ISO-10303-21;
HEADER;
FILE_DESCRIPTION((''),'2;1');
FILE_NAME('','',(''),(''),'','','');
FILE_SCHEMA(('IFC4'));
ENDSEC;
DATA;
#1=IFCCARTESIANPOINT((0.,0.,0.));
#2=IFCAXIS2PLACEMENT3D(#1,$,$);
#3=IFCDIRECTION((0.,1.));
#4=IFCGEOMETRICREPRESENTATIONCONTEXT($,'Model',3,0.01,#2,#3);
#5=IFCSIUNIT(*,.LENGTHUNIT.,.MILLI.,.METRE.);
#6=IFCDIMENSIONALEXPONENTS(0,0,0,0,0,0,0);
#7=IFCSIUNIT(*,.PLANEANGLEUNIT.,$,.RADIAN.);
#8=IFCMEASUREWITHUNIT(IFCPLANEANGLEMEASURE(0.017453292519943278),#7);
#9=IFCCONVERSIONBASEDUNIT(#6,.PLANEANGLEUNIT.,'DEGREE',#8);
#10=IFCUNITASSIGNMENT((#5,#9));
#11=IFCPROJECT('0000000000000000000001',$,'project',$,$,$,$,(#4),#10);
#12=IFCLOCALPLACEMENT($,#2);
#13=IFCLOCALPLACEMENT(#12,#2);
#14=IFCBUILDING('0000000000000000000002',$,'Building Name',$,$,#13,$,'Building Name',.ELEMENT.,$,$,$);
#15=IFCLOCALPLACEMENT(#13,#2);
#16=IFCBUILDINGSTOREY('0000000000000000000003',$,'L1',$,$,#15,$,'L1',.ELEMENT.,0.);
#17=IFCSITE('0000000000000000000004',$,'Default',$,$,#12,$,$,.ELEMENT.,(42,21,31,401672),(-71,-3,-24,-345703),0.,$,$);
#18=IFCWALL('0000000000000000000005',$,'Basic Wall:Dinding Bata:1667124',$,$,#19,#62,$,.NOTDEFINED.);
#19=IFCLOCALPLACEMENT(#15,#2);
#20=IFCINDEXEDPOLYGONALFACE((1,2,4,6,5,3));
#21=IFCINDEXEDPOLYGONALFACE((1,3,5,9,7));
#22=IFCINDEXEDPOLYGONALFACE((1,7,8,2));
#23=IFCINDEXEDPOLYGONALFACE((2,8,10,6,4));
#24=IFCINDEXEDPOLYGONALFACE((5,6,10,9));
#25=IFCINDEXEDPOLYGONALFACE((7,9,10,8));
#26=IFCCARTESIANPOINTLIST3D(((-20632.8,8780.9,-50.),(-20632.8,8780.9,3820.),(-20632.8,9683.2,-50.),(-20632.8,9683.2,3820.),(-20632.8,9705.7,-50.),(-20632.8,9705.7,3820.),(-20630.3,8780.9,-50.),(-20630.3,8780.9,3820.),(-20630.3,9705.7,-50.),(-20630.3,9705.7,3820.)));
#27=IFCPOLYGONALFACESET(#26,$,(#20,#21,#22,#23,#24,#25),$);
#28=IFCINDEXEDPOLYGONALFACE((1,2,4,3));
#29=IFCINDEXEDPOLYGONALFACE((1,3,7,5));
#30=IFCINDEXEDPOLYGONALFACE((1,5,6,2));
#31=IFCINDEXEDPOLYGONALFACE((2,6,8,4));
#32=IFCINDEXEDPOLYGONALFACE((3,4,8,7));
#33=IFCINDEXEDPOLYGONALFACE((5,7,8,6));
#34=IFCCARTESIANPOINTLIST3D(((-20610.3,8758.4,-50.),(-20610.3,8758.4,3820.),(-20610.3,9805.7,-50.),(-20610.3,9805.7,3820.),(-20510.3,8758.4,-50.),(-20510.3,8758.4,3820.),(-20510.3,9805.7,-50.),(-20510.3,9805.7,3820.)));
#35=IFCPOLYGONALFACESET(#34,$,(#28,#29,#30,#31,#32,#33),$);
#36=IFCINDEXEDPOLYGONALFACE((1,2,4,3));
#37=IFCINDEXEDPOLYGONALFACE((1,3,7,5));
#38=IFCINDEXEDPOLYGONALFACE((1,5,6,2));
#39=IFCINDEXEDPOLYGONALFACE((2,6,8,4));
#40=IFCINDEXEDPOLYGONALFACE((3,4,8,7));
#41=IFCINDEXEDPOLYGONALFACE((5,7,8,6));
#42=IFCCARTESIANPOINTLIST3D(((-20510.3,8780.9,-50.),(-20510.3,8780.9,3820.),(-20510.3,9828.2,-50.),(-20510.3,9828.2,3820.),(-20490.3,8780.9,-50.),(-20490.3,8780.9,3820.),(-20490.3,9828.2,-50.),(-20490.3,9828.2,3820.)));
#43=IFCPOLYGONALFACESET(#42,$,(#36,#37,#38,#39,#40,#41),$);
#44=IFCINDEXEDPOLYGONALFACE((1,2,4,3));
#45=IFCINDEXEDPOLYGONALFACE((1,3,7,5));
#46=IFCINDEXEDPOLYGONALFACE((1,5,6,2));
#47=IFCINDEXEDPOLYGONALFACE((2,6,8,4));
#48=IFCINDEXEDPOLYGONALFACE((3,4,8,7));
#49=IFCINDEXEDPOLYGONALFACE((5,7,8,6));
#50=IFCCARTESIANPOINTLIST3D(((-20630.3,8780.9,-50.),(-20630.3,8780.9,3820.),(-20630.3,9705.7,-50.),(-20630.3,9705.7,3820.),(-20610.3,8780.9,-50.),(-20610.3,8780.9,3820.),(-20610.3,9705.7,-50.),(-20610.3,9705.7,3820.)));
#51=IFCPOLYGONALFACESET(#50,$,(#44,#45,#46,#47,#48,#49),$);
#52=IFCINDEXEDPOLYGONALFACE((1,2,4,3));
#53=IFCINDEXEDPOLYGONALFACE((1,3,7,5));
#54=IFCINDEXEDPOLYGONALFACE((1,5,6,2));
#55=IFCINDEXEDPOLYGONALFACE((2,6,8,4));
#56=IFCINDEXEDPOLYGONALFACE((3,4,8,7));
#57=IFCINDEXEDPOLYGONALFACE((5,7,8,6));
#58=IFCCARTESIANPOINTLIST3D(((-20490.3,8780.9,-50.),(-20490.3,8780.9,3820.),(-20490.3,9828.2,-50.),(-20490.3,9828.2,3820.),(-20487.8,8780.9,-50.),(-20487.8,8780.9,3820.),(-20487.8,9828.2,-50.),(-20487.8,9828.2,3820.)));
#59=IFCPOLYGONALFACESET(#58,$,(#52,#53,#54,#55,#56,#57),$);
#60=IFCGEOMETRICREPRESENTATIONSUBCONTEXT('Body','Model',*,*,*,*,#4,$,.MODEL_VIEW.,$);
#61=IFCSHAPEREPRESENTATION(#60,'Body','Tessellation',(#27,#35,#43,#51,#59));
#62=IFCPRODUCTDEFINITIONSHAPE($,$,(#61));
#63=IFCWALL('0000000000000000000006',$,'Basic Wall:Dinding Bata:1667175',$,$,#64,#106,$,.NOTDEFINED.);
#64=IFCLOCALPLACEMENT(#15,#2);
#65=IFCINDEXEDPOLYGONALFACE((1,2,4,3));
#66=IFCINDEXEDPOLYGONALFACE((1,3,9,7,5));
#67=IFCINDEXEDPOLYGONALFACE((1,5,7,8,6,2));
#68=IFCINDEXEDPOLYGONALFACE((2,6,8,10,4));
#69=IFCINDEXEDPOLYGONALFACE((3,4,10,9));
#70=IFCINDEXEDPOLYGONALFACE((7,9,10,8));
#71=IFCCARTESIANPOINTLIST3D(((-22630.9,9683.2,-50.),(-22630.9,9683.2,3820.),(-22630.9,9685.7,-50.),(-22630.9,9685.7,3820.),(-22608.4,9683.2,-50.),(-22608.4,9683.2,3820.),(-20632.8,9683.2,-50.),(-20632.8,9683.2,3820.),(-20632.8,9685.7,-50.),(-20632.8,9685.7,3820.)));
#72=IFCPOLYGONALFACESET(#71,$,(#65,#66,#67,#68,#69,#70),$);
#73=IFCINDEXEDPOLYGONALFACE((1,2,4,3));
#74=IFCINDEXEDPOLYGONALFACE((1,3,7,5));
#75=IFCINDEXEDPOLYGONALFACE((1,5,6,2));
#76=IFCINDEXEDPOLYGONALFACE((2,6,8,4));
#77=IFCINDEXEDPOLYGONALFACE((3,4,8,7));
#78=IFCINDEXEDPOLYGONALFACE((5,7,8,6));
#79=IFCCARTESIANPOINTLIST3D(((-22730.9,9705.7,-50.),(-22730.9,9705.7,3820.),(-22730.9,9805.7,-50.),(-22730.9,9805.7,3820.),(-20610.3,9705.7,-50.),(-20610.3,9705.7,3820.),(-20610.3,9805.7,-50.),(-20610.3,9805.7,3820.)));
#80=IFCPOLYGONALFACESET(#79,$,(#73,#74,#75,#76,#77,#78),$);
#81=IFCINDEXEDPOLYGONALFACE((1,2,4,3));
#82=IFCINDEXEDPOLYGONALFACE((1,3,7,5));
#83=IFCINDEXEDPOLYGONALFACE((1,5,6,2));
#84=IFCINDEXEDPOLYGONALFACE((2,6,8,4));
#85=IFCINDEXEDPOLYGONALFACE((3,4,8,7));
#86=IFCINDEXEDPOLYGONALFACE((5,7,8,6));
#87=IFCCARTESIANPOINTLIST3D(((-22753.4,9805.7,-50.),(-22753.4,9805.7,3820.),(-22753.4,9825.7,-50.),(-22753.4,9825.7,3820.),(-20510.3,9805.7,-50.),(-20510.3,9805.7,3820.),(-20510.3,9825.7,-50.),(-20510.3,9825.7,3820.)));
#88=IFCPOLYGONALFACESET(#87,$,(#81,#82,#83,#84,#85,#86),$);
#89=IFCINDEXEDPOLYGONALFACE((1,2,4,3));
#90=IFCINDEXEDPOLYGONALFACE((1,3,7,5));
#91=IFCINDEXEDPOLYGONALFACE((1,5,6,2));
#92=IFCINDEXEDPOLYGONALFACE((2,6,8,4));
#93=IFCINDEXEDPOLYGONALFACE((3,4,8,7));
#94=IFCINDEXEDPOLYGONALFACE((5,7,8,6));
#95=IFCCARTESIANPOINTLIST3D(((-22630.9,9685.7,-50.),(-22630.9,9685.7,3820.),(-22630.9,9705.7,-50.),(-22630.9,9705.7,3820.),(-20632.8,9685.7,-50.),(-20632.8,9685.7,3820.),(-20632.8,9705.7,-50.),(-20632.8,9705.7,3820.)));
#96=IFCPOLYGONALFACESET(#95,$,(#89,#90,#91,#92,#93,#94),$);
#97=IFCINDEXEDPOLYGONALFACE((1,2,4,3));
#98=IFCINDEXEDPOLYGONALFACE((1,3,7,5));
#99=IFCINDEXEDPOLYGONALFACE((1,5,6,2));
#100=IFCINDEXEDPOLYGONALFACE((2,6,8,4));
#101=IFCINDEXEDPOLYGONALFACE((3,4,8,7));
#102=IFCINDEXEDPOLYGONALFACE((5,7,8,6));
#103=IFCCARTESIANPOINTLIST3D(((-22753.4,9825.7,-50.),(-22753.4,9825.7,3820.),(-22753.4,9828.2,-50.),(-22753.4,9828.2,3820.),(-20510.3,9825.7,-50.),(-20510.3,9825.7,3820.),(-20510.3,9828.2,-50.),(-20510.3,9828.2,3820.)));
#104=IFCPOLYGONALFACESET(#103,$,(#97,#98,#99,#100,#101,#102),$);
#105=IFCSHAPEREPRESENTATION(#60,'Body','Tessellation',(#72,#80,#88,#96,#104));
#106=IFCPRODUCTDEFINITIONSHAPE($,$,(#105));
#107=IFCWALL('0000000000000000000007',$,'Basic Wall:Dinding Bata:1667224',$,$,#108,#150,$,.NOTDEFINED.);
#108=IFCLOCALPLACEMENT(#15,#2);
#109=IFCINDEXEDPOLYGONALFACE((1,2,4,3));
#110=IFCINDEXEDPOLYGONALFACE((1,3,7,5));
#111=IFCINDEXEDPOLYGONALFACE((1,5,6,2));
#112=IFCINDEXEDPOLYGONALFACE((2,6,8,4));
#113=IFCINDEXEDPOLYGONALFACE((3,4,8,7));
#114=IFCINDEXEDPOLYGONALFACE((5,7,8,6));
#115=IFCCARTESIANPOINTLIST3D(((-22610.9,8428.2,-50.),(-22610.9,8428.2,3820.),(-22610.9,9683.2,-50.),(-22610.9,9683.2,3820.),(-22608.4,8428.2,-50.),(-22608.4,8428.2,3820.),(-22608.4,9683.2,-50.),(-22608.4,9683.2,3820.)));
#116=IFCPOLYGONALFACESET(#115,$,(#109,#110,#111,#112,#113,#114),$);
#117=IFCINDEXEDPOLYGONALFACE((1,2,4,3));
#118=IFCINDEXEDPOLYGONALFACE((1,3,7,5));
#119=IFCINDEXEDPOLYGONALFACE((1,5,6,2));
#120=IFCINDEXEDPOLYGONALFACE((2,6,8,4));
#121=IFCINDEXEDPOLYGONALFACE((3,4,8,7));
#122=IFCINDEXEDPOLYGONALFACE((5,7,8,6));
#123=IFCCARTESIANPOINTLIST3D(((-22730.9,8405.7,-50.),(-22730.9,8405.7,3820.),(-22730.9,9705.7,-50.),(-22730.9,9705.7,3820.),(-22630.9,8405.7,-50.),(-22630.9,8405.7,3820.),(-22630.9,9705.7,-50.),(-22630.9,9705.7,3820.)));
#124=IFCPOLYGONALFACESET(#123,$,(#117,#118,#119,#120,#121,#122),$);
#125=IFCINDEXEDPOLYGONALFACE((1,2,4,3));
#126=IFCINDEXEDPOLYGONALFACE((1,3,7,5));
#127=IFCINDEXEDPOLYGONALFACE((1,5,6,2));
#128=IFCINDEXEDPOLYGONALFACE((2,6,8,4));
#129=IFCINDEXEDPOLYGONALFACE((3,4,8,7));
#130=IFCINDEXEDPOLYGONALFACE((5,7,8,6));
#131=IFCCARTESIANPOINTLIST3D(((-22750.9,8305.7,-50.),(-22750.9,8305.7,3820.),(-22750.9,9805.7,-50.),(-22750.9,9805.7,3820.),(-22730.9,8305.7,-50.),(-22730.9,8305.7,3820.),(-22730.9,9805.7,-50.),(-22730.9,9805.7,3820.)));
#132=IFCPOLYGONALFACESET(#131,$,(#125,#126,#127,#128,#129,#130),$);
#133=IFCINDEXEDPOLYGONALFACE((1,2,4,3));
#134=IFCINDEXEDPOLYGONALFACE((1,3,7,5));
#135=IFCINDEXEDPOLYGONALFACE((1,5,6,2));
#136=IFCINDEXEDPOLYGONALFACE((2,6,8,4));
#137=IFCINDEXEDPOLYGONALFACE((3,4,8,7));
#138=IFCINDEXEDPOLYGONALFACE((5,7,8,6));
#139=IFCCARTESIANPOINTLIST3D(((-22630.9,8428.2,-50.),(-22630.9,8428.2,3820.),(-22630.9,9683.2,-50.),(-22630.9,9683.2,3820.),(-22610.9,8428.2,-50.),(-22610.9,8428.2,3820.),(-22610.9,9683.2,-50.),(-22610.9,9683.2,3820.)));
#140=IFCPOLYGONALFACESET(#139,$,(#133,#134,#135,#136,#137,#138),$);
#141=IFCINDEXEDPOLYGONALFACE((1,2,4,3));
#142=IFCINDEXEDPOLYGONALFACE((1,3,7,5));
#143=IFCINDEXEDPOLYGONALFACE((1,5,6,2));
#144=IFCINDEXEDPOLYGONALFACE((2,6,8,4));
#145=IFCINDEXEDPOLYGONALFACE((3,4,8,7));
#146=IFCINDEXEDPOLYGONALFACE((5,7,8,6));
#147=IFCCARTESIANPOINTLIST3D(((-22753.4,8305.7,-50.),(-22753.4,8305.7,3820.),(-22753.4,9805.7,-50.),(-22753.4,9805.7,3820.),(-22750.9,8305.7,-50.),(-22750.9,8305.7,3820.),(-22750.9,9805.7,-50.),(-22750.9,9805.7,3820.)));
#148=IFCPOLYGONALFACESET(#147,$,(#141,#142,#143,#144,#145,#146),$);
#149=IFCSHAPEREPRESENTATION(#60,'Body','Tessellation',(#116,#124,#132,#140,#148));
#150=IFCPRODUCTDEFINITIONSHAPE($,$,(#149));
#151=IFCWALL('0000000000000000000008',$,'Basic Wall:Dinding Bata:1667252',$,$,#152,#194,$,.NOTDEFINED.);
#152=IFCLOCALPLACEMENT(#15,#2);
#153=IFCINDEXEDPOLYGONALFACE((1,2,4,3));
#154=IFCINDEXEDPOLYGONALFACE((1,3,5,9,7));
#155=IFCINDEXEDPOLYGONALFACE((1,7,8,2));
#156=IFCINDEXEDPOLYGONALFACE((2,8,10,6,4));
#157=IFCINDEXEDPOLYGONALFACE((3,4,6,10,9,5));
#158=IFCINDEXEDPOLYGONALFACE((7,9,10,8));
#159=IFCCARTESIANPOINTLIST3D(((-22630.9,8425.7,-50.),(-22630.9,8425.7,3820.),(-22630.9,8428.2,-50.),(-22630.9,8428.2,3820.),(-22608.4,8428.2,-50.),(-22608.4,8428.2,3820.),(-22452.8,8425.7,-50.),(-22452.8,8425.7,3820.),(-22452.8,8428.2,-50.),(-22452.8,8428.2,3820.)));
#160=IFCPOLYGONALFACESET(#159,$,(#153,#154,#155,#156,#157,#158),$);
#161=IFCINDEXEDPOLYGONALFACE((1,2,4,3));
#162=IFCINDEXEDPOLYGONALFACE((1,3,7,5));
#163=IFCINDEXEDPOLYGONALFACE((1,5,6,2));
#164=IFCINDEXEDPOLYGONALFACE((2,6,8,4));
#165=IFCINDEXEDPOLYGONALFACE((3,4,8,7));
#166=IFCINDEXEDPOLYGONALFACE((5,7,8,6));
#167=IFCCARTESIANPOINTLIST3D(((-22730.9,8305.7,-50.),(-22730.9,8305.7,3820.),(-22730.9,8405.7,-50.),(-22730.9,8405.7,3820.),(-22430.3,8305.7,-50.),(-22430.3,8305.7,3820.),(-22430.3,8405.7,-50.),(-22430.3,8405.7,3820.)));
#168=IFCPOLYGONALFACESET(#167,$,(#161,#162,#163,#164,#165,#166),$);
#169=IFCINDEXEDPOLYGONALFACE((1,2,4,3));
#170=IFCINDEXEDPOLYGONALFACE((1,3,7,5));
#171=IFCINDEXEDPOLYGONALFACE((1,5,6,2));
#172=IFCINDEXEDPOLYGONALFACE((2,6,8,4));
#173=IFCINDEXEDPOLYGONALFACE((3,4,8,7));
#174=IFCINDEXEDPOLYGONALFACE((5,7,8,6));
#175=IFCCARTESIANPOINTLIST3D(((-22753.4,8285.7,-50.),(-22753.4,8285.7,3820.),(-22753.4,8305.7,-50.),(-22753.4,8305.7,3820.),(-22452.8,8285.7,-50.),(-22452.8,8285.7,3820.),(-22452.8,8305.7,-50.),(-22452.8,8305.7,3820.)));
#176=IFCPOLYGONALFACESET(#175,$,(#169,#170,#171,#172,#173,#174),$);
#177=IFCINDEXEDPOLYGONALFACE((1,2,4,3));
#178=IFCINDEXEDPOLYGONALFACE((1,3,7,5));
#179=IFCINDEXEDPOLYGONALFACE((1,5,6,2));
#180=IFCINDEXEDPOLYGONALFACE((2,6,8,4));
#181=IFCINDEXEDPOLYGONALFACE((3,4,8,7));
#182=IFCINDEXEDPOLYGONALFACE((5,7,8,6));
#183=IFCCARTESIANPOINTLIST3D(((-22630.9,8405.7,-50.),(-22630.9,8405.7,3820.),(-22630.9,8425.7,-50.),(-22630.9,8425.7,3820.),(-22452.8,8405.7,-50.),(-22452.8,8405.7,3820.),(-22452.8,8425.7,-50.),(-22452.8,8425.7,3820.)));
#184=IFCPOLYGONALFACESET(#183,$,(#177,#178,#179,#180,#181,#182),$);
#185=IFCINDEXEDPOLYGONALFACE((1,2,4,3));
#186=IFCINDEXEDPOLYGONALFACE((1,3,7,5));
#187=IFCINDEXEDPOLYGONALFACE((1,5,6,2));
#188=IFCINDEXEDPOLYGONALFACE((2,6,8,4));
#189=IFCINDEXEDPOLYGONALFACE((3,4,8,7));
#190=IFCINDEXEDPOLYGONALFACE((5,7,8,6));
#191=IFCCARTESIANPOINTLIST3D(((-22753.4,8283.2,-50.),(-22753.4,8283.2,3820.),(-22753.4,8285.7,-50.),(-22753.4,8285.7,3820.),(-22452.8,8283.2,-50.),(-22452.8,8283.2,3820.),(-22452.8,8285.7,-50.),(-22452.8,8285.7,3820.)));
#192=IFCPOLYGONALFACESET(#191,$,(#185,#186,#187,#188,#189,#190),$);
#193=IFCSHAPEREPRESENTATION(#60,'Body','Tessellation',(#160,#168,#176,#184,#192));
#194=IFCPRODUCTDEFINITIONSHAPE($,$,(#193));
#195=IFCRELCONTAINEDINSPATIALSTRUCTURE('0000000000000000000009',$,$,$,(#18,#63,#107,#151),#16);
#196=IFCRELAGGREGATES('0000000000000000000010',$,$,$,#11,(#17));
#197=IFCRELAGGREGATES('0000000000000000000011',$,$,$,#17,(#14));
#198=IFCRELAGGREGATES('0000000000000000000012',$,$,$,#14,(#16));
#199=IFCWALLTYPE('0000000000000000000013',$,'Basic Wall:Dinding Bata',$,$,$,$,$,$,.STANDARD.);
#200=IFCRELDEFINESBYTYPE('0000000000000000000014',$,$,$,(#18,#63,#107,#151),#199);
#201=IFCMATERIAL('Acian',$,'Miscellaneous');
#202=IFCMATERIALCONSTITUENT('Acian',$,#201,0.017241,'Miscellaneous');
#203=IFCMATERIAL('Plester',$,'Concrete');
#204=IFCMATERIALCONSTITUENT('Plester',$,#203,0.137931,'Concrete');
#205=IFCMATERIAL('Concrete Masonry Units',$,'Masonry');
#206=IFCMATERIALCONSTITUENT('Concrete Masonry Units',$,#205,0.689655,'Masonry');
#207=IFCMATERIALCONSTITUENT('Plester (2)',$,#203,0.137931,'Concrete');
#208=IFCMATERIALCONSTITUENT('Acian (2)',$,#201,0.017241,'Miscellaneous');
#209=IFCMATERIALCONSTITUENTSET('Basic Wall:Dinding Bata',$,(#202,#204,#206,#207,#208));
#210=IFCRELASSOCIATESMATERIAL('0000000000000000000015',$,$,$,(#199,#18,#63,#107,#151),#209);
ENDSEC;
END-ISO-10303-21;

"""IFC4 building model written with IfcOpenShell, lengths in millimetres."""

from ifc_helpers import new_model, entity, si_unit, converted_unit, direction, frame, origin, place, context, subcontext, project, spatial, indexed_curve, outline, extrude, material, constituent, constituent_set, type_object, element, save


model = new_model("IFC4")

# Units and contexts
model_context = context("Model", 3, precision=0.01, world=origin(), true_north=direction((0.0, 1.0)))
body_context = subcontext(model_context, "Body", "Model", "MODEL_VIEW")
ifc_project = project(units=[si_unit("LENGTHUNIT", "METRE", prefix="MILLI"), converted_unit("PLANEANGLEUNIT", "DEGREE", entity("IfcPlaneAngleMeasure", 0.017453292519943278), si_unit("PLANEANGLEUNIT", "RADIAN"), dimensions=[0, 0, 0, 0, 0, 0, 0])], contexts=[model_context])

# Site, building, storey
site_placement = place(None, origin())
site = spatial("IfcSite", under=ifc_project, at=site_placement, Name="Default", CompositionType="ELEMENT", RefLatitude=(42, 21, 31, 401672), RefLongitude=(-71, -3, -24, -345703), RefElevation=0.0)
building_placement = place(site_placement, origin())
building = spatial("IfcBuilding", under=site, at=building_placement, Name="Building Name", LongName="Building Name", CompositionType="ELEMENT")
storey_placement = place(building_placement, origin())
storey = spatial("IfcBuildingStorey", under=building, at=storey_placement, Name="L1", LongName="L1", CompositionType="ELEMENT", Elevation=0.0)

# Walls
ifc_material_1 = material(Name="Acian", Category="Miscellaneous")
ifc_constituent_1 = constituent(ifc_material_1, Name="Acian", Category="Miscellaneous", fraction=0.017241)
ifc_material_2 = material(Name="Plester", Category="Concrete")
ifc_constituent_2 = constituent(ifc_material_2, Name="Plester", Category="Concrete", fraction=0.137931)
ifc_material_3 = material(Name="Concrete Masonry Units", Category="Masonry")
ifc_constituent_3 = constituent(ifc_material_3, Name="Concrete Masonry Units", Category="Masonry", fraction=0.689655)
ifc_constituent_4 = constituent(ifc_material_2, Name="Plester (2)", Category="Concrete", fraction=0.137931)
ifc_constituent_5 = constituent(ifc_material_1, Name="Acian (2)", Category="Miscellaneous", fraction=0.017241)
ifc_constituent_set = constituent_set(constituents=[ifc_constituent_1, ifc_constituent_2, ifc_constituent_3, ifc_constituent_4, ifc_constituent_5], Name="Basic Wall:Dinding Bata")
wall_type = type_object("IfcWallType", Name="Basic Wall:Dinding Bata", PredefinedType="STANDARD", material=ifc_constituent_set)
wall_1_placement = place(storey_placement, frame((-20560.3, 8780.9, -50.0), z_axis=(0.0, 0.0, 1.0), x_axis=(0.0, 1.0, 0.0)))
element("IfcWall", 1, at=wall_1_placement, inside=storey, type_object=wall_type, material=ifc_constituent_set, Name="Basic Wall:Dinding Bata:1667124", PredefinedType="NOTDEFINED", context=body_context, shape_type="SweptSolid", body=[
    extrude(outline(indexed_curve([(-351.9, -1.0), (550.4, -1.0), (550.4, 1.5), (-374.4, 1.5), (-374.4, -1.0), (-351.9, -1.0)], self_intersect=False)), frame((550.4, 71.5, 0.0), z_axis=(0.0, 0.0, 1.0), x_axis=(-1.0, 0.0, 0.0)), (0.0, 0.0, 1.0), 3870.0),
    extrude(outline(indexed_curve([(-523.7, -50.0), (523.7, -50.0), (523.7, 50.0), (-523.7, 50.0), (-523.7, -50.0)], self_intersect=False)), frame((501.2, 0.0, 0.0)), (0.0, 0.0, 1.0), 3870.0),
    extrude(outline(indexed_curve([(-523.7, -10.0), (523.7, -10.0), (523.7, 10.0), (-523.7, 10.0), (-523.7, -10.0)], self_intersect=False)), frame((523.7, -60.0, 0.0)), (0.0, 0.0, 1.0), 3870.0),
    extrude(outline(indexed_curve([(-462.4, -10.0), (462.4, -10.0), (462.4, 10.0), (-462.4, 10.0), (-462.4, -10.0)], self_intersect=False)), frame((462.4, 60.0, 0.0)), (0.0, 0.0, 1.0), 3870.0),
    extrude(outline(indexed_curve([(-1.2, -523.7), (1.2, -523.7), (1.2, 523.7), (-1.2, 523.7), (-1.2, -523.7)], self_intersect=False)), frame((523.7, -71.3, 0.0), z_axis=(0.0, 0.0, 1.0), x_axis=(0.0, 1.0, 0.0)), (0.0, 0.0, 1.0), 3870.0),
])
wall_2_placement = place(storey_placement, frame((-20632.8, 9755.7, -50.0), z_axis=(0.0, 0.0, 1.0), x_axis=(-1.0, 0.0, 0.0)))
element("IfcWall", 2, at=wall_2_placement, inside=storey, type_object=wall_type, material=ifc_constituent_set, Name="Basic Wall:Dinding Bata:1667175", PredefinedType="NOTDEFINED", context=body_context, shape_type="SweptSolid", body=[
    extrude(outline(indexed_curve([(-781.2, -1.0), (1194.4, -1.0), (1194.4, 1.5), (-803.7, 1.5), (-803.7, -1.0), (-781.2, -1.0)], self_intersect=False)), frame((1194.4, 71.5, 0.0), z_axis=(0.0, 0.0, 1.0), x_axis=(-1.0, 0.0, 0.0)), (0.0, 0.0, 1.0), 3870.0),
    extrude(outline(indexed_curve([(-1060.3, -50.0), (1060.3, -50.0), (1060.3, 50.0), (-1060.3, 50.0), (-1060.3, -50.0)], self_intersect=False)), frame((1037.8, 0.0, 0.0)), (0.0, 0.0, 1.0), 3870.0),
    extrude(outline(indexed_curve([(-1121.5, -10.0), (1121.5, -10.0), (1121.5, 10.0), (-1121.5, 10.0), (-1121.5, -10.0)], self_intersect=False)), frame((999.0, -60.0, 0.0)), (0.0, 0.0, 1.0), 3870.0),
    extrude(outline(indexed_curve([(-999.0, -10.0), (999.0, -10.0), (999.0, 10.0), (-999.0, 10.0), (-999.0, -10.0)], self_intersect=False)), frame((999.0, 60.0, 0.0)), (0.0, 0.0, 1.0), 3870.0),
    extrude(outline(indexed_curve([(-1.3, -1121.5), (1.2, -1121.5), (1.3, 1121.5), (-1.2, 1121.5), (-1.3, -1121.5)], self_intersect=False)), frame((999.0, -71.2, 0.0), z_axis=(0.0, 0.0, 1.0), x_axis=(0.0, 1.0, 0.0)), (0.0, 0.0, 1.0), 3870.0),
])
wall_3_placement = place(storey_placement, frame((-22680.9, 9683.2, -50.0), z_axis=(0.0, 0.0, 1.0), x_axis=(0.0, -1.0, 0.0)))
element("IfcWall", 3, at=wall_3_placement, inside=storey, type_object=wall_type, material=ifc_constituent_set, Name="Basic Wall:Dinding Bata:1667224", PredefinedType="NOTDEFINED", context=body_context, shape_type="SweptSolid", body=[
    extrude(outline(indexed_curve([(-1.2, -627.5), (1.2, -627.5), (1.3, 627.5), (-1.2, 627.5), (-1.2, -627.5)], self_intersect=False)), frame((627.5, 71.3, 0.0), z_axis=(0.0, 0.0, 1.0), x_axis=(0.0, -1.0, 0.0)), (0.0, 0.0, 1.0), 3870.0),
    extrude(outline(indexed_curve([(-650.0, -50.0), (650.0, -50.0), (650.0, 50.0), (-650.0, 50.0), (-650.0, -50.0)], self_intersect=False)), frame((627.5, 0.0, 0.0)), (0.0, 0.0, 1.0), 3870.0),
    extrude(outline(indexed_curve([(-750.0, -10.0), (750.0, -10.0), (750.0, 10.0), (-750.0, 10.0), (-750.0, -10.0)], self_intersect=False)), frame((627.5, -60.0, 0.0)), (0.0, 0.0, 1.0), 3870.0),
    extrude(outline(indexed_curve([(-627.5, -10.0), (627.5, -10.0), (627.5, 10.0), (-627.5, 10.0), (-627.5, -10.0)], self_intersect=False)), frame((627.5, 60.0, 0.0)), (0.0, 0.0, 1.0), 3870.0),
    extrude(outline(indexed_curve([(-1.3, -750.0), (1.2, -750.0), (1.2, 750.0), (-1.2, 750.0), (-1.3, -750.0)], self_intersect=False)), frame((627.5, -71.2, 0.0), z_axis=(0.0, 0.0, 1.0), x_axis=(0.0, 1.0, 0.0)), (0.0, 0.0, 1.0), 3870.0),
])
wall_4_placement = place(storey_placement, frame((-22753.4, 8355.7, -50.0)))
element("IfcWall", 4, at=wall_4_placement, inside=storey, type_object=wall_type, material=ifc_constituent_set, Name="Basic Wall:Dinding Bata:1667252", PredefinedType="NOTDEFINED", context=body_context, shape_type="SweptSolid", body=[
    extrude(outline(indexed_curve([(53.2, -1.0), (75.7, -1.0), (75.7, 1.5), (-102.4, 1.5), (-102.4, -1.0), (53.2, -1.0)], self_intersect=False)), frame((198.2, 71.5, 0.0), z_axis=(0.0, 0.0, 1.0), x_axis=(-1.0, 0.0, 0.0)), (0.0, 0.0, 1.0), 3870.0),
    extrude(outline(indexed_curve([(-150.3, -50.0), (150.3, -50.0), (150.3, 50.0), (-150.3, 50.0), (-150.3, -50.0)], self_intersect=False)), frame((172.8, 0.0, 0.0)), (0.0, 0.0, 1.0), 3870.0),
    extrude(outline(indexed_curve([(-150.3, -10.0), (150.3, -10.0), (150.3, 10.0), (-150.3, 10.0), (-150.3, -10.0)], self_intersect=False)), frame((150.3, -60.0, 0.0)), (0.0, 0.0, 1.0), 3870.0),
    extrude(outline(indexed_curve([(-89.0, -10.0), (89.0, -10.0), (89.0, 10.0), (-89.0, 10.0), (-89.0, -10.0)], self_intersect=False)), frame((211.5, 60.0, 0.0)), (0.0, 0.0, 1.0), 3870.0),
    extrude(outline(indexed_curve([(-1.2, -150.3), (1.2, -150.3), (1.3, 150.3), (-1.2, 150.3), (-1.2, -150.3)], self_intersect=False)), frame((150.3, -71.3, 0.0), z_axis=(0.0, 0.0, 1.0), x_axis=(0.0, 1.0, 0.0)), (0.0, 0.0, 1.0), 3870.0),
])

save(model, "model.ifc")
